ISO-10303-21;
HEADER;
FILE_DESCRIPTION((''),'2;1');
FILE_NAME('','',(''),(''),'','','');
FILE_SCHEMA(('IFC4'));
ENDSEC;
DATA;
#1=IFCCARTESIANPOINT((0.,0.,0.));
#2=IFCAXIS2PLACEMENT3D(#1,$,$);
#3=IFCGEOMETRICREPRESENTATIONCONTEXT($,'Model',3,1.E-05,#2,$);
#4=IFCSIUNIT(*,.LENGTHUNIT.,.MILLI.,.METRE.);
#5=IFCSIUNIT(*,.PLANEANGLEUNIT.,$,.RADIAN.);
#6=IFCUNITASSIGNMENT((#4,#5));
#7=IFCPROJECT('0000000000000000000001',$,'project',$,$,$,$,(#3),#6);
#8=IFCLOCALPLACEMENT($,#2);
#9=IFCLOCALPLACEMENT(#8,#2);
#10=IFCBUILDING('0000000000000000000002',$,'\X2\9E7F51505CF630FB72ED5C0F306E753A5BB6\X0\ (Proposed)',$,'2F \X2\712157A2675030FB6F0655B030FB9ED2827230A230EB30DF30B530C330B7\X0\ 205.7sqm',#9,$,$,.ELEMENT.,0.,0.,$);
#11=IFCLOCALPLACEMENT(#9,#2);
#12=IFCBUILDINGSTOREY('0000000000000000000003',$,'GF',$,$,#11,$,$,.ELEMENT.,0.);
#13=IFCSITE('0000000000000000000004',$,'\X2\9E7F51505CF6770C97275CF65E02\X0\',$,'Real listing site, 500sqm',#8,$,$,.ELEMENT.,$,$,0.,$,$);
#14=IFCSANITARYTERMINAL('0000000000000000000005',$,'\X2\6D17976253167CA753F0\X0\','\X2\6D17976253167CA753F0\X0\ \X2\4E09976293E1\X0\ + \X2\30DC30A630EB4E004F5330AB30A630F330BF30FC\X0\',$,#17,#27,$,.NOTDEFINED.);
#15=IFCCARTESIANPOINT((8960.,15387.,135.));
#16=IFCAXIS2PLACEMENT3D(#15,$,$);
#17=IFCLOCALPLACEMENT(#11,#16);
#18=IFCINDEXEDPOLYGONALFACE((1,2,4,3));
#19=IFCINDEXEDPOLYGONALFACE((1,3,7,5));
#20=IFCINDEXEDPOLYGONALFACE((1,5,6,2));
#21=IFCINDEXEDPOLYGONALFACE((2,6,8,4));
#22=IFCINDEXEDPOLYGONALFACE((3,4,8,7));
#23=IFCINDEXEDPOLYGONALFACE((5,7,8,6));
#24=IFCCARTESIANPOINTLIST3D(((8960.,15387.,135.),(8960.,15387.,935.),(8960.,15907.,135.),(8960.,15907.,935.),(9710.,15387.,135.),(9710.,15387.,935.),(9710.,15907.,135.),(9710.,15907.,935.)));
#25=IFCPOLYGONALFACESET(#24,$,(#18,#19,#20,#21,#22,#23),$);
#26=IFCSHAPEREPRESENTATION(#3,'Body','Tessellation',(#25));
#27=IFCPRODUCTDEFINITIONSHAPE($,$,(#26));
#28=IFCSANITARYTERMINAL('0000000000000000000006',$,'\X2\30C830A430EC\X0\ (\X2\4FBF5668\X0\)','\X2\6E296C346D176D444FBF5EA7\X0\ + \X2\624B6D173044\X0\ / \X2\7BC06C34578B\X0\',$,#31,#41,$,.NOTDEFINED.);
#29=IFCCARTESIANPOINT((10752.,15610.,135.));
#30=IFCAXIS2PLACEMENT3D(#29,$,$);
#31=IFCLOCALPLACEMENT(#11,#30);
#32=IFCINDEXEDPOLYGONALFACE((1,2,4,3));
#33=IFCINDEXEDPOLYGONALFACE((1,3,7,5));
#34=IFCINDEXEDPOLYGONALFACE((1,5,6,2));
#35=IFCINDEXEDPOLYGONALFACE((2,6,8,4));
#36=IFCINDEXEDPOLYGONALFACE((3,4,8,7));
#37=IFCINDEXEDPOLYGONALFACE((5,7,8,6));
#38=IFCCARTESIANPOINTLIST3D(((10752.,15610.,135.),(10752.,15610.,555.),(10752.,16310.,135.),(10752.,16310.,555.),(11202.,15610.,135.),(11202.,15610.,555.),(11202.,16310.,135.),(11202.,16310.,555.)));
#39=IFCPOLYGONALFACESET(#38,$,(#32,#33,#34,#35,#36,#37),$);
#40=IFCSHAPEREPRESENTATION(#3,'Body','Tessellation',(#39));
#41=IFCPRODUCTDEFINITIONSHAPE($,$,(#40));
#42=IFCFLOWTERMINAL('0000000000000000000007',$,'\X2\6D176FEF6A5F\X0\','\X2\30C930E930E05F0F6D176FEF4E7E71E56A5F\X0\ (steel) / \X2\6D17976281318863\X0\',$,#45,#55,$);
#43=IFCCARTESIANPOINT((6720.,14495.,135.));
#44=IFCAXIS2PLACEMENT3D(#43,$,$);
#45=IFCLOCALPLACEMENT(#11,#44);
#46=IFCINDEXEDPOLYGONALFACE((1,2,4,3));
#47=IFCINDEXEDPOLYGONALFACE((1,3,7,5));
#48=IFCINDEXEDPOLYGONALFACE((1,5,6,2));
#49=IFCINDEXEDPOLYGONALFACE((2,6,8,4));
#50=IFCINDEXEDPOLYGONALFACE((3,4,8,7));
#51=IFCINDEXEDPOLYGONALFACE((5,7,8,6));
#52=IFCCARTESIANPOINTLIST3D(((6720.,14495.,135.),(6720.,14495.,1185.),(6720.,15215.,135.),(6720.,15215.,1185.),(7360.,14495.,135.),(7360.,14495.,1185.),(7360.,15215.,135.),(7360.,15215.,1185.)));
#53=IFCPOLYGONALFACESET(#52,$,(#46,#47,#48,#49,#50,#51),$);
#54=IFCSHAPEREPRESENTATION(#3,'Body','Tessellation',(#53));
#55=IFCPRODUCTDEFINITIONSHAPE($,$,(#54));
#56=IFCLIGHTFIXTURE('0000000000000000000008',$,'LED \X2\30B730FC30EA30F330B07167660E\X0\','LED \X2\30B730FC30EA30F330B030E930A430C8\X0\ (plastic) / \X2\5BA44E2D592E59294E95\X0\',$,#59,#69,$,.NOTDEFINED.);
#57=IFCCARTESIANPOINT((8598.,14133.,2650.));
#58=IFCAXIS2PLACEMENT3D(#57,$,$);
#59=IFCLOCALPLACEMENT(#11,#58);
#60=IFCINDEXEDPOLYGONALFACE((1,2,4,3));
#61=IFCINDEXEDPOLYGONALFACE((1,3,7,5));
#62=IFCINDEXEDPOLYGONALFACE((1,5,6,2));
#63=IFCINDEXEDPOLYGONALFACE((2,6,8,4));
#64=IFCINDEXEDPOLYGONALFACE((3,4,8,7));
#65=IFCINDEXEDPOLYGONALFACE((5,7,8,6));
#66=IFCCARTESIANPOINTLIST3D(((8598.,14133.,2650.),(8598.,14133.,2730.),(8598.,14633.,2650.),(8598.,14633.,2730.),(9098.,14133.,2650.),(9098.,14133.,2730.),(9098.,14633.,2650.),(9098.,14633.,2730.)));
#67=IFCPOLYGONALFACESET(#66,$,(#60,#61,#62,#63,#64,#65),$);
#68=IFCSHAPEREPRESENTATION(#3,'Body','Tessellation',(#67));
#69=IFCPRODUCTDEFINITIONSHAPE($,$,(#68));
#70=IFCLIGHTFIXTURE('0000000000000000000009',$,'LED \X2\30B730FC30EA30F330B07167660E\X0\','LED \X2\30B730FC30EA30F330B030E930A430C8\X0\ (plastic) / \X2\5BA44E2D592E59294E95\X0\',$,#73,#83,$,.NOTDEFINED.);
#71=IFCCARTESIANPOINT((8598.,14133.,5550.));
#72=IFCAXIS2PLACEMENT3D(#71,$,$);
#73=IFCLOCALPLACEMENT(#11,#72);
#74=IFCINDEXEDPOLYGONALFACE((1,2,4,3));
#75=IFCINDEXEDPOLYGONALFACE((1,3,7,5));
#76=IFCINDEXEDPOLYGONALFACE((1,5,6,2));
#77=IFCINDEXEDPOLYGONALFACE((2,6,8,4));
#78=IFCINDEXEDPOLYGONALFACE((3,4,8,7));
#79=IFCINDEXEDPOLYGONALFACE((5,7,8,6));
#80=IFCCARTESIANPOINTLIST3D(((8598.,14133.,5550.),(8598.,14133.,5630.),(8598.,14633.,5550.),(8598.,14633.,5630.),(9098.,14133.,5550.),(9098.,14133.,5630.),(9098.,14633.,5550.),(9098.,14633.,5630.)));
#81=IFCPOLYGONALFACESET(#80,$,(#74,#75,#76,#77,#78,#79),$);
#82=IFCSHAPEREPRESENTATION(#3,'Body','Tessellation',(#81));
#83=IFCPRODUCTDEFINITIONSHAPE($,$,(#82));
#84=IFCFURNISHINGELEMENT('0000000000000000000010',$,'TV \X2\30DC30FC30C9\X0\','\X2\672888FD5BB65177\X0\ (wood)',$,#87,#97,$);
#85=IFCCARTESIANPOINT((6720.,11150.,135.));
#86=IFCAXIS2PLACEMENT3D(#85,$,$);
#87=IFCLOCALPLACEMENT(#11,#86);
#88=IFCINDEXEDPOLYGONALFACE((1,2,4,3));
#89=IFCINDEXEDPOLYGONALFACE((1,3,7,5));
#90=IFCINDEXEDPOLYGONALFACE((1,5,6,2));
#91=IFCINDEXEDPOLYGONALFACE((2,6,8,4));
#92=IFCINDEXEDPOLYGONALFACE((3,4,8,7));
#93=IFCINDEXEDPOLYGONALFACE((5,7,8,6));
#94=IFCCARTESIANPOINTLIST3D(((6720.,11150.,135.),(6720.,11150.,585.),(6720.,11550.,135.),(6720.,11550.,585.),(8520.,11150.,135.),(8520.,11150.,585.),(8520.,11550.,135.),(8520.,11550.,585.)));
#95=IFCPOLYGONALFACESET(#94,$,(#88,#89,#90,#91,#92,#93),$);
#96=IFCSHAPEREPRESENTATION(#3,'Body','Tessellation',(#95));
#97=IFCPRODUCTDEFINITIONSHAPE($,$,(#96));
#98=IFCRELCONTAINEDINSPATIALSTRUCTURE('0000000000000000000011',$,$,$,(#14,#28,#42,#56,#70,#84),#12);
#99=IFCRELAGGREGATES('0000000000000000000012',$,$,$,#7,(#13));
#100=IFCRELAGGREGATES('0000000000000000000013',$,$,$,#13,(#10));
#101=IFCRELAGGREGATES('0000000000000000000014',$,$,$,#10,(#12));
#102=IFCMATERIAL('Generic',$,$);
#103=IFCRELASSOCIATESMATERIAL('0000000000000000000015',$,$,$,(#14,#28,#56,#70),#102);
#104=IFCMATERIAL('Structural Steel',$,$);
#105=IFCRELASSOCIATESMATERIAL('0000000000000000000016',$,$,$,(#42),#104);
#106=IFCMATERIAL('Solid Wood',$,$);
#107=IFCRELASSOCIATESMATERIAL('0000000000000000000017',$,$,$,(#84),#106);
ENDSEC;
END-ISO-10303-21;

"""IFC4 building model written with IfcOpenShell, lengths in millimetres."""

from ifc_helpers import new_model, si_unit, frame, frame_2d, origin, place, context, project, spatial, rectangle, extrude, material, element, save


model = new_model("IFC4")

# Units and contexts
model_context = context("Model", 3, precision=1e-05, world=origin())
ifc_project = project(units=[si_unit("LENGTHUNIT", "METRE", prefix="MILLI"), si_unit("PLANEANGLEUNIT", "RADIAN")], contexts=[model_context])

# Site, building, storey
site_placement = place(None, origin())
site = spatial("IfcSite", under=ifc_project, at=site_placement, Name="鹿児島県霧島市", ObjectType="Real listing site, 500sqm", CompositionType="ELEMENT", RefElevation=0.0)
building_placement = place(site_placement, origin())
building = spatial("IfcBuilding", under=site, at=building_placement, Name="鹿児島・狭小の町家 (Proposed)", ObjectType="2F 無垢材・漆喰・黒色アルミサッシ 205.7sqm", CompositionType="ELEMENT", ElevationOfRefHeight=0.0, ElevationOfTerrain=0.0)
storey_placement = place(building_placement, origin())
storey = spatial("IfcBuildingStorey", under=building, at=storey_placement, Name="GF", CompositionType="ELEMENT", Elevation=0.0)

# Shared definitions
ifc_material_1 = material(Name="Solid Wood")

# Sanitary terminals
ifc_material_2 = material(Name="Generic")
sanitary_terminal_1_placement = place(storey_placement, frame((8960.0, 15387.0, 135.0)))
element("IfcSanitaryTerminal", 1, at=sanitary_terminal_1_placement, inside=storey, material=ifc_material_2, Name="洗面化粧台", Description="洗面化粧台 三面鏡 + ボウル一体カウンター", PredefinedType="NOTDEFINED", context=model_context, shape_type="SweptSolid", body=[
    extrude(rectangle(XDim=750.0, YDim=520.0, at=frame_2d((375.0, 260.0))), frame((8960.0, 15387.0, 135.0)), (0.0, 0.0, 1.0), 800.0),
])
sanitary_terminal_2_placement = place(storey_placement, frame((10752.0, 15610.0, 135.0)))
element("IfcSanitaryTerminal", 2, at=sanitary_terminal_2_placement, inside=storey, material=ifc_material_2, Name="トイレ (便器)", Description="温水洗浄便座 + 手洗い / 節水型", PredefinedType="NOTDEFINED", context=model_context, shape_type="SweptSolid", body=[
    extrude(rectangle(XDim=450.0, YDim=700.0, at=frame_2d((225.0, 350.0))), frame((10752.0, 15610.0, 135.0)), (0.0, 0.0, 1.0), 420.0),
])

# Flow terminal
ifc_material_3 = material(Name="Structural Steel")
flow_terminal_placement = place(storey_placement, frame((6720.0, 14495.0, 135.0)))
element("IfcFlowTerminal", 3, at=flow_terminal_placement, inside=storey, material=ifc_material_3, Name="洗濯機", Description="ドラム式洗濯乾燥機 (steel) / 洗面脱衣", context=model_context, shape_type="SweptSolid", body=[
    extrude(rectangle(XDim=640.0, YDim=720.0, at=frame_2d((320.0, 360.0))), frame((6720.0, 14495.0, 135.0)), (0.0, 0.0, 1.0), 1050.0),
])

# Light fixtures
light_fixture_1_placement = place(storey_placement, frame((8598.0, 14133.0, 2650.0)))
element("IfcLightFixture", 4, at=light_fixture_1_placement, inside=storey, material=ifc_material_2, Name="LED シーリング照明", Description="LED シーリングライト (plastic) / 室中央天井", PredefinedType="NOTDEFINED", context=model_context, shape_type="SweptSolid", body=[
    extrude(rectangle(XDim=500.0, YDim=500.0, at=frame_2d((250.0, 250.0))), frame((8598.0, 14133.0, 2650.0)), (0.0, 0.0, 1.0), 80.0),
])
light_fixture_2_placement = place(storey_placement, frame((8598.0, 14133.0, 5550.0)))
element("IfcLightFixture", 5, at=light_fixture_2_placement, inside=storey, material=ifc_material_2, Name="LED シーリング照明", Description="LED シーリングライト (plastic) / 室中央天井", PredefinedType="NOTDEFINED", context=model_context, shape_type="SweptSolid", body=[
    extrude(rectangle(XDim=500.0, YDim=500.0, at=frame_2d((250.0, 250.0))), frame((8598.0, 14133.0, 5550.0)), (0.0, 0.0, 1.0), 80.0),
])

# Furnishing element
furnishing_placement = place(storey_placement, frame((6720.0, 11150.0, 135.0)))
element("IfcFurnishingElement", 6, at=furnishing_placement, inside=storey, material=ifc_material_1, Name="TV ボード", Description="木製家具 (wood)", context=model_context, shape_type="SweptSolid", body=[
    extrude(rectangle(XDim=1800.0, YDim=400.0, at=frame_2d((900.0, 200.0))), frame((6720.0, 11150.0, 135.0)), (0.0, 0.0, 1.0), 450.0),
])

save(model, "model.ifc")
